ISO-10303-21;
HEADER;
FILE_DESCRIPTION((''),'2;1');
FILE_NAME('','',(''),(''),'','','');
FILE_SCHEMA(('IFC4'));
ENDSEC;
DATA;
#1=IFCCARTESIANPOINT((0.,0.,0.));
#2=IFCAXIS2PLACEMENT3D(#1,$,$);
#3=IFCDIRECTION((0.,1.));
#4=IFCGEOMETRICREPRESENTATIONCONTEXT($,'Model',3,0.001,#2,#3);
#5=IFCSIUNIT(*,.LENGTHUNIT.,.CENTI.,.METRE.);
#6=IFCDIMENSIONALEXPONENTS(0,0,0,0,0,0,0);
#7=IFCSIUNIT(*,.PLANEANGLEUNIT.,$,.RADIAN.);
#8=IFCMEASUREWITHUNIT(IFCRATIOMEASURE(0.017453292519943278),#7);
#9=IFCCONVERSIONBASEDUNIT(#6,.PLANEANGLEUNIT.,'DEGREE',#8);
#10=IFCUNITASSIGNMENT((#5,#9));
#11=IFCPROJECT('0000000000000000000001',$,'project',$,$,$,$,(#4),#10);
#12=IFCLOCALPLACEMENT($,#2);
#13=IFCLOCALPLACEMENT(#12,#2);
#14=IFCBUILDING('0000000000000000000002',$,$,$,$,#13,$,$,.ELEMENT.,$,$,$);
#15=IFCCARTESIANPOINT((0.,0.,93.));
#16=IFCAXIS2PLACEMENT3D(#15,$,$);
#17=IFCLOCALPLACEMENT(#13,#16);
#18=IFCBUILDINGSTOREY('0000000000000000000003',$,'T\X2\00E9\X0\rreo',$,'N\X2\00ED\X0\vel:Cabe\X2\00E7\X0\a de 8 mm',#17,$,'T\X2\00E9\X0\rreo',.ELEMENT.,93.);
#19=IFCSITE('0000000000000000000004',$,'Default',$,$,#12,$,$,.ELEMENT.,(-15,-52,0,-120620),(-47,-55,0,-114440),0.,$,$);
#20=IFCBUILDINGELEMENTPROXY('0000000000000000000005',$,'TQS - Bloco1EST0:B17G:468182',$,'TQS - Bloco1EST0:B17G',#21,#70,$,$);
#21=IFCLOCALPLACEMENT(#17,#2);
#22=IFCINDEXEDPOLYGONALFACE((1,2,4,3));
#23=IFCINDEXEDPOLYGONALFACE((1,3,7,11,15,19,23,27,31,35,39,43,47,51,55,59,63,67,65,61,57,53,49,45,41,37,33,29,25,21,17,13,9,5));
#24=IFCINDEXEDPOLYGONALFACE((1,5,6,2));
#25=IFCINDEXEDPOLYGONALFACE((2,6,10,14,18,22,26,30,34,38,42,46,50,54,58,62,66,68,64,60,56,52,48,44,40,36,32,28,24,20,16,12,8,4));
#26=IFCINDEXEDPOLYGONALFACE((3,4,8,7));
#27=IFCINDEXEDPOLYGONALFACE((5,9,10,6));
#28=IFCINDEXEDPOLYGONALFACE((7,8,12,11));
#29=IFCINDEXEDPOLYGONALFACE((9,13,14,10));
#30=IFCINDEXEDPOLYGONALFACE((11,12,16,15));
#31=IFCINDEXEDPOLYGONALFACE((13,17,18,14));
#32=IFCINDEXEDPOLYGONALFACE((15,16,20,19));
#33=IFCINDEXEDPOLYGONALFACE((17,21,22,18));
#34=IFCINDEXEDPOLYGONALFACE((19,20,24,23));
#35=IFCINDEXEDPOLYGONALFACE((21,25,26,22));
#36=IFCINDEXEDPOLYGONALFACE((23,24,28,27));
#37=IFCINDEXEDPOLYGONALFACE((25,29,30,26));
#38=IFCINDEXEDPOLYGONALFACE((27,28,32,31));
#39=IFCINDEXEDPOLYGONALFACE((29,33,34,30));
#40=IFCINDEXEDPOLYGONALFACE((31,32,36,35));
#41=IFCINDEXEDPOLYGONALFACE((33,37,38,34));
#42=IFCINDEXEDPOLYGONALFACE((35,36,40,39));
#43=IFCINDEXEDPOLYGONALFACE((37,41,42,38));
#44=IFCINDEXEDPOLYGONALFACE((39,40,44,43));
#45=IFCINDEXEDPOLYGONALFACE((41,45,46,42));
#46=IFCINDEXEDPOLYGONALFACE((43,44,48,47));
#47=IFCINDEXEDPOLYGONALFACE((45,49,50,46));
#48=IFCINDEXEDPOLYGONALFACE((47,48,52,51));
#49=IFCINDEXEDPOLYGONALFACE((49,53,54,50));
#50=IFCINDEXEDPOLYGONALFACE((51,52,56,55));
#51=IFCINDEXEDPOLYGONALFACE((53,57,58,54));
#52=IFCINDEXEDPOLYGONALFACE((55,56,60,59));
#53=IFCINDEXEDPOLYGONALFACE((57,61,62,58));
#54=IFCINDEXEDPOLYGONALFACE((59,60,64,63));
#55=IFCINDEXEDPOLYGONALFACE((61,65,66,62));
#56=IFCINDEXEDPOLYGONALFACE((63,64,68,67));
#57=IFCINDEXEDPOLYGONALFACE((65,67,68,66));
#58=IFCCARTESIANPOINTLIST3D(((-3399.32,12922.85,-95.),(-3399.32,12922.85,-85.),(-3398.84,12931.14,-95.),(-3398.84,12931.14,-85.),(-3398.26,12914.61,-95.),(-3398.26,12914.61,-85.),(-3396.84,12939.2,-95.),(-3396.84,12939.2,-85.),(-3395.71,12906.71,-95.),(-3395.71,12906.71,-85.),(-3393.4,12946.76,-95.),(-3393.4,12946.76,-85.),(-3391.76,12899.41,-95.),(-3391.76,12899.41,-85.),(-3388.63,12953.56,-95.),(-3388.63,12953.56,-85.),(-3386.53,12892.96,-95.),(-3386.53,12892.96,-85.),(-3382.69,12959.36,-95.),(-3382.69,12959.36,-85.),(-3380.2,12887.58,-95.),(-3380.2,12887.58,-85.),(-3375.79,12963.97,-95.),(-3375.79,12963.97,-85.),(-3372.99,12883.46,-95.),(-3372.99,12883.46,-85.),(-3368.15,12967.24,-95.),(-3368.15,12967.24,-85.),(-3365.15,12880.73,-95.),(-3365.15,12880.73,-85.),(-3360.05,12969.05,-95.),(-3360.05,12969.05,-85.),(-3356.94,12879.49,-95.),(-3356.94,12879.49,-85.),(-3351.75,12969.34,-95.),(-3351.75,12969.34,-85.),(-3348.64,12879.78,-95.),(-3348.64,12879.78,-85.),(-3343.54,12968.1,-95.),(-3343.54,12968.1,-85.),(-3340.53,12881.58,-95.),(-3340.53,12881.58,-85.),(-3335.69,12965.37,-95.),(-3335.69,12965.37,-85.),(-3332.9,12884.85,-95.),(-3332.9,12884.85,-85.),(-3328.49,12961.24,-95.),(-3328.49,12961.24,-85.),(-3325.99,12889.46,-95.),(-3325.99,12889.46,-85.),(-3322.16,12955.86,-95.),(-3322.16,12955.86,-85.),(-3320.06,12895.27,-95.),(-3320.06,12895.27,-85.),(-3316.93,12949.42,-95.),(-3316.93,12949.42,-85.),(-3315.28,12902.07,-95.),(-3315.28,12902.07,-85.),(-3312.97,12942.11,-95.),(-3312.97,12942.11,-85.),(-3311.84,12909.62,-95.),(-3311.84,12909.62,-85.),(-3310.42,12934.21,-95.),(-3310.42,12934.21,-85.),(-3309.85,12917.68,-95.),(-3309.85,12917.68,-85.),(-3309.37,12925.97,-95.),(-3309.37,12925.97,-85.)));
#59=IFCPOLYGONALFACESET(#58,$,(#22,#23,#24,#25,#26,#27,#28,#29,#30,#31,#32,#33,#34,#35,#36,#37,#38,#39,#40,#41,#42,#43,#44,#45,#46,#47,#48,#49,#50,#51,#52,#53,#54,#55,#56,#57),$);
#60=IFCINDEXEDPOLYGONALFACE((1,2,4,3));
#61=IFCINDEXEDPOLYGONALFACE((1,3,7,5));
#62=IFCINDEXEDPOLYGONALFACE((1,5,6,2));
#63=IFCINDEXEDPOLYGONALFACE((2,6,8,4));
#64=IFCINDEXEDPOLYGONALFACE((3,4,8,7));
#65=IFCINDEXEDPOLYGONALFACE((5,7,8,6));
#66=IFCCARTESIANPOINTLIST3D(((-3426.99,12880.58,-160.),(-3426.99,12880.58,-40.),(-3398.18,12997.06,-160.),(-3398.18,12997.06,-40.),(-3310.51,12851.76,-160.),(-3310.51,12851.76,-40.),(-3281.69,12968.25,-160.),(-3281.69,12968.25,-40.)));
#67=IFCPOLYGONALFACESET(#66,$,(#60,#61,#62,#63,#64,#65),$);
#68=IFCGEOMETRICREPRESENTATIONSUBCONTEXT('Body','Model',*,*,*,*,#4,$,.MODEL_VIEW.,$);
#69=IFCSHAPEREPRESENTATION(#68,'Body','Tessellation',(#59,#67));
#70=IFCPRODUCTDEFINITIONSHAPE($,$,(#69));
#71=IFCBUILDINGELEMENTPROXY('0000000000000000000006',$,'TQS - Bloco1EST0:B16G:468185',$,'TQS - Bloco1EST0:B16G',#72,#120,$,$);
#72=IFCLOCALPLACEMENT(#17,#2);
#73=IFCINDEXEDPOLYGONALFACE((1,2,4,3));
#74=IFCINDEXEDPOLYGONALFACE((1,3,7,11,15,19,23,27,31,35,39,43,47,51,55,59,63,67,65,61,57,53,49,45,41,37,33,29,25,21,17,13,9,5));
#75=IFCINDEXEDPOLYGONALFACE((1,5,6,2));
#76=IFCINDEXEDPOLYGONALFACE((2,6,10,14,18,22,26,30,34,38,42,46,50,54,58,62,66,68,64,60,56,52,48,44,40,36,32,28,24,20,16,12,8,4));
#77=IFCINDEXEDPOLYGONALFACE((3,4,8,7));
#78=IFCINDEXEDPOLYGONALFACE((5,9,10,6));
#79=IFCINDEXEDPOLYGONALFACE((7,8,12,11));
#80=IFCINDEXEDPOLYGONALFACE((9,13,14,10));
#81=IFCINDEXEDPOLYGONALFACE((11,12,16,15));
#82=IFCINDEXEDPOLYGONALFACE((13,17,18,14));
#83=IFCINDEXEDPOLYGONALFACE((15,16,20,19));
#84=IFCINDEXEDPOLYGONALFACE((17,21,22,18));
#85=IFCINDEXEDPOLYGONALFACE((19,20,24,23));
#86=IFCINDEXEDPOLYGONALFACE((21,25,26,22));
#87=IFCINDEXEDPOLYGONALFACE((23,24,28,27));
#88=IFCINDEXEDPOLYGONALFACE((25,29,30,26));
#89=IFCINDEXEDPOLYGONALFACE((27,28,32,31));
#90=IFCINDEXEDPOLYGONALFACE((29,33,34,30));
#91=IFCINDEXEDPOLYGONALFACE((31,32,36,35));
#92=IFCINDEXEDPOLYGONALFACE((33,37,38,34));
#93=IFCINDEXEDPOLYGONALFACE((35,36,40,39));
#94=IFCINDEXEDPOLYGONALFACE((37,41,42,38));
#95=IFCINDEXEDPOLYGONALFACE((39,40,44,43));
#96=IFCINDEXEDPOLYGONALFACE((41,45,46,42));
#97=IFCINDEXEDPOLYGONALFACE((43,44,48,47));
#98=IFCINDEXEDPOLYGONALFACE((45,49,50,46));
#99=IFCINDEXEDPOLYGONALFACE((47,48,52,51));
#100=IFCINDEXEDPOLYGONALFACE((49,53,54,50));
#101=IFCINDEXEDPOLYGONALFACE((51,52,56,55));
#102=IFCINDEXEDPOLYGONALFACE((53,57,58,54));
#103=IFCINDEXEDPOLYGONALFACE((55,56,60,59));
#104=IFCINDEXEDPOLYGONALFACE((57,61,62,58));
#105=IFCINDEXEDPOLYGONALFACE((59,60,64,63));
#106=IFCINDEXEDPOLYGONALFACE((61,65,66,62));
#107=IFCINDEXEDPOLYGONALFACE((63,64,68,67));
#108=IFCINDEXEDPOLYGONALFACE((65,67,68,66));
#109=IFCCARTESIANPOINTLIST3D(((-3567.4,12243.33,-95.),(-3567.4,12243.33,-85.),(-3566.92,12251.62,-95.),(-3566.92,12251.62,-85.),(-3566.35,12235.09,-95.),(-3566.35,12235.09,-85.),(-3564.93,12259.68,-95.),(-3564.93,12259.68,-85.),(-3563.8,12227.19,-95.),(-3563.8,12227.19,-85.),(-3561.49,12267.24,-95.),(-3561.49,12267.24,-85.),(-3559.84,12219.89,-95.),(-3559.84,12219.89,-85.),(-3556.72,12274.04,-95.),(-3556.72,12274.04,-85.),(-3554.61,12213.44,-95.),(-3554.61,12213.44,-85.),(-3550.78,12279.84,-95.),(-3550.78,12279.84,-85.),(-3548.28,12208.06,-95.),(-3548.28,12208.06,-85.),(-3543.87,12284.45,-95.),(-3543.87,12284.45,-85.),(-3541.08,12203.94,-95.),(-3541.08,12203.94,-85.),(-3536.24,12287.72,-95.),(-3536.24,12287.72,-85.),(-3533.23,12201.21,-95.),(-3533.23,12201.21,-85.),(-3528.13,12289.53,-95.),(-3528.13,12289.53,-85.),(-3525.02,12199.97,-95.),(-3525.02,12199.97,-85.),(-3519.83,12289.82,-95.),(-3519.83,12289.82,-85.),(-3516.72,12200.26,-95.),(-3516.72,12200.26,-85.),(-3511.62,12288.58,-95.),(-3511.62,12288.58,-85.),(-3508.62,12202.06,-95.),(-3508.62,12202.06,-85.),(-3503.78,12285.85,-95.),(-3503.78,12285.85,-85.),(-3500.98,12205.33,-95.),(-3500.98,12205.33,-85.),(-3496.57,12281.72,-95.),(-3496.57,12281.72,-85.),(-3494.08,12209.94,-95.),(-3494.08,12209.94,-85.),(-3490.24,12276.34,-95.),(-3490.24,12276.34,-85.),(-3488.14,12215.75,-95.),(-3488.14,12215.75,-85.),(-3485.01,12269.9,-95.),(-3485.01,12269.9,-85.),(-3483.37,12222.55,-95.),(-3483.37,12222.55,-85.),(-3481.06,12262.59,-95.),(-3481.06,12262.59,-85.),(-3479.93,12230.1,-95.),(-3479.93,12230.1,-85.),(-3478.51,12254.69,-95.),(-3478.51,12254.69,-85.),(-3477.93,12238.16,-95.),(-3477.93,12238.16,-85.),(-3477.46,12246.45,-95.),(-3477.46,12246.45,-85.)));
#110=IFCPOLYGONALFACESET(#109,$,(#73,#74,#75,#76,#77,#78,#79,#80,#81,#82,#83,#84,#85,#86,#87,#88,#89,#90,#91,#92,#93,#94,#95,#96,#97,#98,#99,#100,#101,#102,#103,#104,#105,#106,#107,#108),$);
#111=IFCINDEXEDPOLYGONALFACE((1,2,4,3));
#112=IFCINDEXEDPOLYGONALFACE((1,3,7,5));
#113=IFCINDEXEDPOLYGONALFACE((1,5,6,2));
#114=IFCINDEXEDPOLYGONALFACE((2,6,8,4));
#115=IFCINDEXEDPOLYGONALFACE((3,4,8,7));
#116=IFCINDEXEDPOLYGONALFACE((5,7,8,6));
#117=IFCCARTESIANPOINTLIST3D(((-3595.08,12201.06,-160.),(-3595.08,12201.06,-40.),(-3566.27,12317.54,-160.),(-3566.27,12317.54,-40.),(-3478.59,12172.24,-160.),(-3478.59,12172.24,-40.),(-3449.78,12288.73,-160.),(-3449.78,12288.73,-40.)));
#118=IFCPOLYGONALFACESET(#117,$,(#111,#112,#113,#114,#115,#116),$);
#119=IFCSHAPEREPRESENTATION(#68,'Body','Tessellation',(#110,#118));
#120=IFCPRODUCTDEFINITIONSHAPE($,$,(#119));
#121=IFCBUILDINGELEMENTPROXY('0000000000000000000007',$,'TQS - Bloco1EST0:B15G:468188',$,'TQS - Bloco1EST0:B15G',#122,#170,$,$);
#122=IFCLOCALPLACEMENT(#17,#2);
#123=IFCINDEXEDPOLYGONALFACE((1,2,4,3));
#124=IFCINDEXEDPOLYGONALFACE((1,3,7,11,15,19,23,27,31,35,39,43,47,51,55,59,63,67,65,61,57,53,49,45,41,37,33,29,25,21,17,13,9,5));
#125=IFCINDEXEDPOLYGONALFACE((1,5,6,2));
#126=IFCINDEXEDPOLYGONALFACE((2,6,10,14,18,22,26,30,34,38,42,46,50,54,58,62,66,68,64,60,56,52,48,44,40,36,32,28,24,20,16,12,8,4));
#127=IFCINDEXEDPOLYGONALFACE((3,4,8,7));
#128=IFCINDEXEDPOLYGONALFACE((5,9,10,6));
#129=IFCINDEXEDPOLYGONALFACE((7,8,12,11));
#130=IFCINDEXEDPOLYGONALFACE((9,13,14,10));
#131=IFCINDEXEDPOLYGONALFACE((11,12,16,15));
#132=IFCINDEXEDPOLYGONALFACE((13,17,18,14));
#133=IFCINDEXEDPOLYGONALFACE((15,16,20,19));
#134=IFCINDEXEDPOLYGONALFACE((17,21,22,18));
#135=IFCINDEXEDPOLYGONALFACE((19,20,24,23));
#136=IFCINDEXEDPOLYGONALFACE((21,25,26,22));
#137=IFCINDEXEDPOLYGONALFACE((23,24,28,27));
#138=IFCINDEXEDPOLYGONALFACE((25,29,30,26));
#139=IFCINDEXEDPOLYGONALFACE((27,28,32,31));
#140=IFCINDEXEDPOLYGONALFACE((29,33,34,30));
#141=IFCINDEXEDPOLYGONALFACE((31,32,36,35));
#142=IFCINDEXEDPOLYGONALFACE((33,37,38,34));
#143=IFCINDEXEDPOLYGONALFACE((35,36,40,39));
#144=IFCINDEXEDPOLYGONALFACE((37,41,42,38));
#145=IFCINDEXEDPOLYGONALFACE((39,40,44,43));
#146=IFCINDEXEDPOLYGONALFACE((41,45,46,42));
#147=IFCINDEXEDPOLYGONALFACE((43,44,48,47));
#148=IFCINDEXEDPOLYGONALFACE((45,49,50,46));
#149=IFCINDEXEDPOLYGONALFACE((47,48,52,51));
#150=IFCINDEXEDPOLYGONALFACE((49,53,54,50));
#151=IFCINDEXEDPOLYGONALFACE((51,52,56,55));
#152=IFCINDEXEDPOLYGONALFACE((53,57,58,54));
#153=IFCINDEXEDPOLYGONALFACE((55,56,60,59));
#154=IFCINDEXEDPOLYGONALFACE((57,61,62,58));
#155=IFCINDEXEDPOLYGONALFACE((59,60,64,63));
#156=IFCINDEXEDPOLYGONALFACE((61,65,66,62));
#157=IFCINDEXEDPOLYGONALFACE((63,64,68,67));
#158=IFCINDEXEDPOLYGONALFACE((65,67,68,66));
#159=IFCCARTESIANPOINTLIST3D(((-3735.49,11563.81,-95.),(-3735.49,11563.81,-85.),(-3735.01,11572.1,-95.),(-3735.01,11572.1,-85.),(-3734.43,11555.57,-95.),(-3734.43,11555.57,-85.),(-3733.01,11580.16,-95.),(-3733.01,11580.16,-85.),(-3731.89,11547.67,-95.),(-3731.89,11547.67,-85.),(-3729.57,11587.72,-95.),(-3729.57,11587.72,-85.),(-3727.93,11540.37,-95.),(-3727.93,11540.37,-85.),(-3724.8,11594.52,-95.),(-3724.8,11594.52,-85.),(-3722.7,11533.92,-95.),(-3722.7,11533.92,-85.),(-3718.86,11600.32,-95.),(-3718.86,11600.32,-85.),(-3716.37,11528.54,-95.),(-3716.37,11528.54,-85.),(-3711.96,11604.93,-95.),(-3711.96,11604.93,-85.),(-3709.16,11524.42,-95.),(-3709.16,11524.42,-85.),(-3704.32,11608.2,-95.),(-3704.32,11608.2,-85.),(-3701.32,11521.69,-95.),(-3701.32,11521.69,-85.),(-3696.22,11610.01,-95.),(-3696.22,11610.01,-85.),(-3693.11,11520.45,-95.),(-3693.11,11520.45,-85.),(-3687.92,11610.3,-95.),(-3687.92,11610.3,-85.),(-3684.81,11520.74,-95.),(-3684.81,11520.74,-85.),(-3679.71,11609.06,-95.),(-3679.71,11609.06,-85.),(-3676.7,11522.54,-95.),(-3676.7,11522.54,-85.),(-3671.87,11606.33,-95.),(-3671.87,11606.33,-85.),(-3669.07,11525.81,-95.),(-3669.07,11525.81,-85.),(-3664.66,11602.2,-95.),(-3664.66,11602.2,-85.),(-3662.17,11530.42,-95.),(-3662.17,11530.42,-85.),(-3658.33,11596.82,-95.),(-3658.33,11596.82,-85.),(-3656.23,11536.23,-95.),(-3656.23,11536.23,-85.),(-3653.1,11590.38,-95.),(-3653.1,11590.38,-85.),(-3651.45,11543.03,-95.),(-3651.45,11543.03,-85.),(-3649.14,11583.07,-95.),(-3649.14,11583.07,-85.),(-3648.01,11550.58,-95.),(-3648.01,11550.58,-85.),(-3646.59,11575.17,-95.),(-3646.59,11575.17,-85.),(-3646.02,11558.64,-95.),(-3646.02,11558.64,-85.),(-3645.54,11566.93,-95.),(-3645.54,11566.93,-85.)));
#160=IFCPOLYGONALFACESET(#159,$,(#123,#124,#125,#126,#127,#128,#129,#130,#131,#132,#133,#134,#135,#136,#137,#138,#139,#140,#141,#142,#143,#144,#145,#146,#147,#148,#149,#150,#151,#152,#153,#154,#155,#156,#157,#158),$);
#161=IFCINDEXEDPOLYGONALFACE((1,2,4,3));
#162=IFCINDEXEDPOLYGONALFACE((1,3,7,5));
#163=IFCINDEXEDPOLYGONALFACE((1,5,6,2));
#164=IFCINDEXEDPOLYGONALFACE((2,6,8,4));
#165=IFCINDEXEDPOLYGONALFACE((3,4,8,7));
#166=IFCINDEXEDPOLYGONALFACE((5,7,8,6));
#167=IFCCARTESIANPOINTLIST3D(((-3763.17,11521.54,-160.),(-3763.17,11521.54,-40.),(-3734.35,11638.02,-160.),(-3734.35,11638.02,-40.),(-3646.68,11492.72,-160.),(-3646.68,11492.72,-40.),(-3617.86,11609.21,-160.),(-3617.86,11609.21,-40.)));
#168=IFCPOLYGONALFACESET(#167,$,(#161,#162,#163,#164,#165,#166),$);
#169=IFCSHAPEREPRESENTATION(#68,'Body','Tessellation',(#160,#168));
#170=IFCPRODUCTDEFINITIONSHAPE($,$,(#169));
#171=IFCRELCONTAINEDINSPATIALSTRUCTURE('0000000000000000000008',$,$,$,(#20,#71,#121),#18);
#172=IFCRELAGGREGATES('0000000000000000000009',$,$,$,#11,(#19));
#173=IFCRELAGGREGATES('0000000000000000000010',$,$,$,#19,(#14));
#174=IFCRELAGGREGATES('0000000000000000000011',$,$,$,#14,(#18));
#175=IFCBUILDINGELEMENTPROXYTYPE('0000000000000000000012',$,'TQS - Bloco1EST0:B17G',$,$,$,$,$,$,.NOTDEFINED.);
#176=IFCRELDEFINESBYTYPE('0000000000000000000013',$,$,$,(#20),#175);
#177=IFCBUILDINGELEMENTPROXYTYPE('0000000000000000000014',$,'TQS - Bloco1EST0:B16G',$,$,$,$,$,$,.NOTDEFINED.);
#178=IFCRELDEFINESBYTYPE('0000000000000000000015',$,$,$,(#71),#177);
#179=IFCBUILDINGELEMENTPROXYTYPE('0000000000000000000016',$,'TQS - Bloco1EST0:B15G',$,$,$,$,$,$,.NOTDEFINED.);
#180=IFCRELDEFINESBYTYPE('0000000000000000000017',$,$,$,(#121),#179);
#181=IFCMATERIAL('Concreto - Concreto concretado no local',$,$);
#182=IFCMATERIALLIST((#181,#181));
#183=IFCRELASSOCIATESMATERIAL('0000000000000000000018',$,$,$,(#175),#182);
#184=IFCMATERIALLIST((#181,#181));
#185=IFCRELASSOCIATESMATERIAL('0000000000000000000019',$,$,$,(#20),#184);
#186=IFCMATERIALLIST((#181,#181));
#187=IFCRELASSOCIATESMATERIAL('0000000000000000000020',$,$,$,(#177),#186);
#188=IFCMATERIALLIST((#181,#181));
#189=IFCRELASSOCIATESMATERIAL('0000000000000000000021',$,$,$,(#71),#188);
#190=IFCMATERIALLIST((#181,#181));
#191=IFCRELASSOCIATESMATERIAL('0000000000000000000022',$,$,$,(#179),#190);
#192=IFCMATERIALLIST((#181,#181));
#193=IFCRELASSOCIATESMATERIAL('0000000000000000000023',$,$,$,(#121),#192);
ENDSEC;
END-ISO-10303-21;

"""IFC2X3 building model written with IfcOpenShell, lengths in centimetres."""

from ifc_helpers import new_model, entity, si_unit, converted_unit, direction, frame, frame_2d, origin, origin_2d_with_axis, place, context, subcontext, project, spatial, rectangle, circle, extrude, source, transform, mapped, material, material_list, type_object, type_shapes, element, save


model = new_model("IFC2X3")

# Units and contexts
model_context = context("Model", 3, precision=0.001, world=origin(), true_north=direction((0.0, 1.0)))
body_context = subcontext(model_context, "Body", "Model", "MODEL_VIEW")
ifc_project = project(units=[si_unit("LENGTHUNIT", "METRE", prefix="CENTI"), converted_unit("PLANEANGLEUNIT", "DEGREE", entity("IfcRatioMeasure", 0.017453292519943278), si_unit("PLANEANGLEUNIT", "RADIAN"), dimensions=[0, 0, 0, 0, 0, 0, 0])], contexts=[model_context])

# Site, building, storey
site_placement = place(None, origin())
site = spatial("IfcSite", under=ifc_project, at=site_placement, Name="Default", CompositionType="ELEMENT", RefLatitude=(-15, -52, 0, -120620), RefLongitude=(-47, -55, 0, -114440), RefElevation=0.0)
building_placement = place(site_placement, origin())
building = spatial("IfcBuilding", under=site, at=building_placement, CompositionType="ELEMENT")
storey_placement = place(building_placement, frame((0.0, 0.0, 93.0)))
storey = spatial("IfcBuildingStorey", under=building, at=storey_placement, Name="Térreo", ObjectType="Nível:Cabeça de 8 mm", LongName="Térreo", CompositionType="ELEMENT", Elevation=93.0)

# Building element proxies
ifc_material_1 = material(Name="Concreto - Concreto concretado no local")
ifc_material_list_1 = material_list([ifc_material_1, ifc_material_1])
ifc_material_list_2 = material_list([ifc_material_1, ifc_material_1])
building_element_proxy_type_1 = type_object("IfcBuildingElementProxyType", Name="TQS - Bloco1EST0:B17G", PredefinedType="NOTDEFINED", material=ifc_material_list_2)
shared_shape_1 = source(origin(), body_context, "Body", "SweptSolid", [
    extrude(circle(Radius=45.0, at=frame_2d((0.0, 0.0), x_axis=(1.0, 0.0))), frame((0.0, 0.0, -55.0)), (0.0, 0.0, 1.0), 10.0),
    extrude(rectangle(XDim=120.0, YDim=120.0, at=origin_2d_with_axis()), frame((0.0, 0.0, -120.0), z_axis=(0.0, 0.0, 1.0), x_axis=(-1.0, 0.0, 0.0)), (0.0, 0.0, 1.0), 120.0),
])
type_shapes(building_element_proxy_type_1, [shared_shape_1])
proxy_1_placement = place(storey_placement, frame((-3354.34, 12924.41, -40.0), z_axis=(0.0, 0.0, 1.0), x_axis=(0.240122, 0.970743, 0.0)))
element("IfcBuildingElementProxy", 1, at=proxy_1_placement, inside=storey, type_object=building_element_proxy_type_1, material=ifc_material_list_1, Name="TQS - Bloco1EST0:B17G:468182", ObjectType="TQS - Bloco1EST0:B17G", context=body_context, shape_type="MappedRepresentation", body=[
    mapped(shared_shape_1, transform((0.0, 0.0, 0.0), scale=1.0)),
])
ifc_material_list_3 = material_list([ifc_material_1, ifc_material_1])
ifc_material_list_4 = material_list([ifc_material_1, ifc_material_1])
building_element_proxy_type_2 = type_object("IfcBuildingElementProxyType", Name="TQS - Bloco1EST0:B16G", PredefinedType="NOTDEFINED", material=ifc_material_list_4)
shared_shape_2 = source(origin(), body_context, "Body", "SweptSolid", [
    extrude(circle(Radius=45.0, at=frame_2d((0.0, 0.0), x_axis=(1.0, 0.0))), frame((0.0, 0.0, -55.0)), (0.0, 0.0, 1.0), 10.0),
    extrude(rectangle(XDim=120.0, YDim=120.0, at=origin_2d_with_axis()), frame((0.0, 0.0, -120.0), z_axis=(0.0, 0.0, 1.0), x_axis=(-1.0, 0.0, 0.0)), (0.0, 0.0, 1.0), 120.0),
])
type_shapes(building_element_proxy_type_2, [shared_shape_2])
proxy_2_placement = place(storey_placement, frame((-3522.43, 12244.89, -40.0), z_axis=(0.0, 0.0, 1.0), x_axis=(0.240122, 0.970743, 0.0)))
element("IfcBuildingElementProxy", 2, at=proxy_2_placement, inside=storey, type_object=building_element_proxy_type_2, material=ifc_material_list_3, Name="TQS - Bloco1EST0:B16G:468185", ObjectType="TQS - Bloco1EST0:B16G", context=body_context, shape_type="MappedRepresentation", body=[
    mapped(shared_shape_2, transform((0.0, 0.0, 0.0), scale=1.0)),
])
ifc_material_list_5 = material_list([ifc_material_1, ifc_material_1])
ifc_material_list_6 = material_list([ifc_material_1, ifc_material_1])
building_element_proxy_type_3 = type_object("IfcBuildingElementProxyType", Name="TQS - Bloco1EST0:B15G", PredefinedType="NOTDEFINED", material=ifc_material_list_6)
shared_shape_3 = source(origin(), body_context, "Body", "SweptSolid", [
    extrude(circle(Radius=45.0, at=frame_2d((0.0, 0.0), x_axis=(1.0, 0.0))), frame((0.0, 0.0, -55.0)), (0.0, 0.0, 1.0), 10.0),
    extrude(rectangle(XDim=120.0, YDim=120.0, at=origin_2d_with_axis()), frame((0.0, 0.0, -120.0), z_axis=(0.0, 0.0, 1.0), x_axis=(-1.0, 0.0, 0.0)), (0.0, 0.0, 1.0), 120.0),
])
type_shapes(building_element_proxy_type_3, [shared_shape_3])
proxy_3_placement = place(storey_placement, frame((-3690.51, 11565.37, -40.0), z_axis=(0.0, 0.0, 1.0), x_axis=(0.240122, 0.970743, 0.0)))
element("IfcBuildingElementProxy", 3, at=proxy_3_placement, inside=storey, type_object=building_element_proxy_type_3, material=ifc_material_list_5, Name="TQS - Bloco1EST0:B15G:468188", ObjectType="TQS - Bloco1EST0:B15G", context=body_context, shape_type="MappedRepresentation", body=[
    mapped(shared_shape_3, transform((0.0, 0.0, 0.0), scale=1.0)),
])

save(model, "model.ifc")
